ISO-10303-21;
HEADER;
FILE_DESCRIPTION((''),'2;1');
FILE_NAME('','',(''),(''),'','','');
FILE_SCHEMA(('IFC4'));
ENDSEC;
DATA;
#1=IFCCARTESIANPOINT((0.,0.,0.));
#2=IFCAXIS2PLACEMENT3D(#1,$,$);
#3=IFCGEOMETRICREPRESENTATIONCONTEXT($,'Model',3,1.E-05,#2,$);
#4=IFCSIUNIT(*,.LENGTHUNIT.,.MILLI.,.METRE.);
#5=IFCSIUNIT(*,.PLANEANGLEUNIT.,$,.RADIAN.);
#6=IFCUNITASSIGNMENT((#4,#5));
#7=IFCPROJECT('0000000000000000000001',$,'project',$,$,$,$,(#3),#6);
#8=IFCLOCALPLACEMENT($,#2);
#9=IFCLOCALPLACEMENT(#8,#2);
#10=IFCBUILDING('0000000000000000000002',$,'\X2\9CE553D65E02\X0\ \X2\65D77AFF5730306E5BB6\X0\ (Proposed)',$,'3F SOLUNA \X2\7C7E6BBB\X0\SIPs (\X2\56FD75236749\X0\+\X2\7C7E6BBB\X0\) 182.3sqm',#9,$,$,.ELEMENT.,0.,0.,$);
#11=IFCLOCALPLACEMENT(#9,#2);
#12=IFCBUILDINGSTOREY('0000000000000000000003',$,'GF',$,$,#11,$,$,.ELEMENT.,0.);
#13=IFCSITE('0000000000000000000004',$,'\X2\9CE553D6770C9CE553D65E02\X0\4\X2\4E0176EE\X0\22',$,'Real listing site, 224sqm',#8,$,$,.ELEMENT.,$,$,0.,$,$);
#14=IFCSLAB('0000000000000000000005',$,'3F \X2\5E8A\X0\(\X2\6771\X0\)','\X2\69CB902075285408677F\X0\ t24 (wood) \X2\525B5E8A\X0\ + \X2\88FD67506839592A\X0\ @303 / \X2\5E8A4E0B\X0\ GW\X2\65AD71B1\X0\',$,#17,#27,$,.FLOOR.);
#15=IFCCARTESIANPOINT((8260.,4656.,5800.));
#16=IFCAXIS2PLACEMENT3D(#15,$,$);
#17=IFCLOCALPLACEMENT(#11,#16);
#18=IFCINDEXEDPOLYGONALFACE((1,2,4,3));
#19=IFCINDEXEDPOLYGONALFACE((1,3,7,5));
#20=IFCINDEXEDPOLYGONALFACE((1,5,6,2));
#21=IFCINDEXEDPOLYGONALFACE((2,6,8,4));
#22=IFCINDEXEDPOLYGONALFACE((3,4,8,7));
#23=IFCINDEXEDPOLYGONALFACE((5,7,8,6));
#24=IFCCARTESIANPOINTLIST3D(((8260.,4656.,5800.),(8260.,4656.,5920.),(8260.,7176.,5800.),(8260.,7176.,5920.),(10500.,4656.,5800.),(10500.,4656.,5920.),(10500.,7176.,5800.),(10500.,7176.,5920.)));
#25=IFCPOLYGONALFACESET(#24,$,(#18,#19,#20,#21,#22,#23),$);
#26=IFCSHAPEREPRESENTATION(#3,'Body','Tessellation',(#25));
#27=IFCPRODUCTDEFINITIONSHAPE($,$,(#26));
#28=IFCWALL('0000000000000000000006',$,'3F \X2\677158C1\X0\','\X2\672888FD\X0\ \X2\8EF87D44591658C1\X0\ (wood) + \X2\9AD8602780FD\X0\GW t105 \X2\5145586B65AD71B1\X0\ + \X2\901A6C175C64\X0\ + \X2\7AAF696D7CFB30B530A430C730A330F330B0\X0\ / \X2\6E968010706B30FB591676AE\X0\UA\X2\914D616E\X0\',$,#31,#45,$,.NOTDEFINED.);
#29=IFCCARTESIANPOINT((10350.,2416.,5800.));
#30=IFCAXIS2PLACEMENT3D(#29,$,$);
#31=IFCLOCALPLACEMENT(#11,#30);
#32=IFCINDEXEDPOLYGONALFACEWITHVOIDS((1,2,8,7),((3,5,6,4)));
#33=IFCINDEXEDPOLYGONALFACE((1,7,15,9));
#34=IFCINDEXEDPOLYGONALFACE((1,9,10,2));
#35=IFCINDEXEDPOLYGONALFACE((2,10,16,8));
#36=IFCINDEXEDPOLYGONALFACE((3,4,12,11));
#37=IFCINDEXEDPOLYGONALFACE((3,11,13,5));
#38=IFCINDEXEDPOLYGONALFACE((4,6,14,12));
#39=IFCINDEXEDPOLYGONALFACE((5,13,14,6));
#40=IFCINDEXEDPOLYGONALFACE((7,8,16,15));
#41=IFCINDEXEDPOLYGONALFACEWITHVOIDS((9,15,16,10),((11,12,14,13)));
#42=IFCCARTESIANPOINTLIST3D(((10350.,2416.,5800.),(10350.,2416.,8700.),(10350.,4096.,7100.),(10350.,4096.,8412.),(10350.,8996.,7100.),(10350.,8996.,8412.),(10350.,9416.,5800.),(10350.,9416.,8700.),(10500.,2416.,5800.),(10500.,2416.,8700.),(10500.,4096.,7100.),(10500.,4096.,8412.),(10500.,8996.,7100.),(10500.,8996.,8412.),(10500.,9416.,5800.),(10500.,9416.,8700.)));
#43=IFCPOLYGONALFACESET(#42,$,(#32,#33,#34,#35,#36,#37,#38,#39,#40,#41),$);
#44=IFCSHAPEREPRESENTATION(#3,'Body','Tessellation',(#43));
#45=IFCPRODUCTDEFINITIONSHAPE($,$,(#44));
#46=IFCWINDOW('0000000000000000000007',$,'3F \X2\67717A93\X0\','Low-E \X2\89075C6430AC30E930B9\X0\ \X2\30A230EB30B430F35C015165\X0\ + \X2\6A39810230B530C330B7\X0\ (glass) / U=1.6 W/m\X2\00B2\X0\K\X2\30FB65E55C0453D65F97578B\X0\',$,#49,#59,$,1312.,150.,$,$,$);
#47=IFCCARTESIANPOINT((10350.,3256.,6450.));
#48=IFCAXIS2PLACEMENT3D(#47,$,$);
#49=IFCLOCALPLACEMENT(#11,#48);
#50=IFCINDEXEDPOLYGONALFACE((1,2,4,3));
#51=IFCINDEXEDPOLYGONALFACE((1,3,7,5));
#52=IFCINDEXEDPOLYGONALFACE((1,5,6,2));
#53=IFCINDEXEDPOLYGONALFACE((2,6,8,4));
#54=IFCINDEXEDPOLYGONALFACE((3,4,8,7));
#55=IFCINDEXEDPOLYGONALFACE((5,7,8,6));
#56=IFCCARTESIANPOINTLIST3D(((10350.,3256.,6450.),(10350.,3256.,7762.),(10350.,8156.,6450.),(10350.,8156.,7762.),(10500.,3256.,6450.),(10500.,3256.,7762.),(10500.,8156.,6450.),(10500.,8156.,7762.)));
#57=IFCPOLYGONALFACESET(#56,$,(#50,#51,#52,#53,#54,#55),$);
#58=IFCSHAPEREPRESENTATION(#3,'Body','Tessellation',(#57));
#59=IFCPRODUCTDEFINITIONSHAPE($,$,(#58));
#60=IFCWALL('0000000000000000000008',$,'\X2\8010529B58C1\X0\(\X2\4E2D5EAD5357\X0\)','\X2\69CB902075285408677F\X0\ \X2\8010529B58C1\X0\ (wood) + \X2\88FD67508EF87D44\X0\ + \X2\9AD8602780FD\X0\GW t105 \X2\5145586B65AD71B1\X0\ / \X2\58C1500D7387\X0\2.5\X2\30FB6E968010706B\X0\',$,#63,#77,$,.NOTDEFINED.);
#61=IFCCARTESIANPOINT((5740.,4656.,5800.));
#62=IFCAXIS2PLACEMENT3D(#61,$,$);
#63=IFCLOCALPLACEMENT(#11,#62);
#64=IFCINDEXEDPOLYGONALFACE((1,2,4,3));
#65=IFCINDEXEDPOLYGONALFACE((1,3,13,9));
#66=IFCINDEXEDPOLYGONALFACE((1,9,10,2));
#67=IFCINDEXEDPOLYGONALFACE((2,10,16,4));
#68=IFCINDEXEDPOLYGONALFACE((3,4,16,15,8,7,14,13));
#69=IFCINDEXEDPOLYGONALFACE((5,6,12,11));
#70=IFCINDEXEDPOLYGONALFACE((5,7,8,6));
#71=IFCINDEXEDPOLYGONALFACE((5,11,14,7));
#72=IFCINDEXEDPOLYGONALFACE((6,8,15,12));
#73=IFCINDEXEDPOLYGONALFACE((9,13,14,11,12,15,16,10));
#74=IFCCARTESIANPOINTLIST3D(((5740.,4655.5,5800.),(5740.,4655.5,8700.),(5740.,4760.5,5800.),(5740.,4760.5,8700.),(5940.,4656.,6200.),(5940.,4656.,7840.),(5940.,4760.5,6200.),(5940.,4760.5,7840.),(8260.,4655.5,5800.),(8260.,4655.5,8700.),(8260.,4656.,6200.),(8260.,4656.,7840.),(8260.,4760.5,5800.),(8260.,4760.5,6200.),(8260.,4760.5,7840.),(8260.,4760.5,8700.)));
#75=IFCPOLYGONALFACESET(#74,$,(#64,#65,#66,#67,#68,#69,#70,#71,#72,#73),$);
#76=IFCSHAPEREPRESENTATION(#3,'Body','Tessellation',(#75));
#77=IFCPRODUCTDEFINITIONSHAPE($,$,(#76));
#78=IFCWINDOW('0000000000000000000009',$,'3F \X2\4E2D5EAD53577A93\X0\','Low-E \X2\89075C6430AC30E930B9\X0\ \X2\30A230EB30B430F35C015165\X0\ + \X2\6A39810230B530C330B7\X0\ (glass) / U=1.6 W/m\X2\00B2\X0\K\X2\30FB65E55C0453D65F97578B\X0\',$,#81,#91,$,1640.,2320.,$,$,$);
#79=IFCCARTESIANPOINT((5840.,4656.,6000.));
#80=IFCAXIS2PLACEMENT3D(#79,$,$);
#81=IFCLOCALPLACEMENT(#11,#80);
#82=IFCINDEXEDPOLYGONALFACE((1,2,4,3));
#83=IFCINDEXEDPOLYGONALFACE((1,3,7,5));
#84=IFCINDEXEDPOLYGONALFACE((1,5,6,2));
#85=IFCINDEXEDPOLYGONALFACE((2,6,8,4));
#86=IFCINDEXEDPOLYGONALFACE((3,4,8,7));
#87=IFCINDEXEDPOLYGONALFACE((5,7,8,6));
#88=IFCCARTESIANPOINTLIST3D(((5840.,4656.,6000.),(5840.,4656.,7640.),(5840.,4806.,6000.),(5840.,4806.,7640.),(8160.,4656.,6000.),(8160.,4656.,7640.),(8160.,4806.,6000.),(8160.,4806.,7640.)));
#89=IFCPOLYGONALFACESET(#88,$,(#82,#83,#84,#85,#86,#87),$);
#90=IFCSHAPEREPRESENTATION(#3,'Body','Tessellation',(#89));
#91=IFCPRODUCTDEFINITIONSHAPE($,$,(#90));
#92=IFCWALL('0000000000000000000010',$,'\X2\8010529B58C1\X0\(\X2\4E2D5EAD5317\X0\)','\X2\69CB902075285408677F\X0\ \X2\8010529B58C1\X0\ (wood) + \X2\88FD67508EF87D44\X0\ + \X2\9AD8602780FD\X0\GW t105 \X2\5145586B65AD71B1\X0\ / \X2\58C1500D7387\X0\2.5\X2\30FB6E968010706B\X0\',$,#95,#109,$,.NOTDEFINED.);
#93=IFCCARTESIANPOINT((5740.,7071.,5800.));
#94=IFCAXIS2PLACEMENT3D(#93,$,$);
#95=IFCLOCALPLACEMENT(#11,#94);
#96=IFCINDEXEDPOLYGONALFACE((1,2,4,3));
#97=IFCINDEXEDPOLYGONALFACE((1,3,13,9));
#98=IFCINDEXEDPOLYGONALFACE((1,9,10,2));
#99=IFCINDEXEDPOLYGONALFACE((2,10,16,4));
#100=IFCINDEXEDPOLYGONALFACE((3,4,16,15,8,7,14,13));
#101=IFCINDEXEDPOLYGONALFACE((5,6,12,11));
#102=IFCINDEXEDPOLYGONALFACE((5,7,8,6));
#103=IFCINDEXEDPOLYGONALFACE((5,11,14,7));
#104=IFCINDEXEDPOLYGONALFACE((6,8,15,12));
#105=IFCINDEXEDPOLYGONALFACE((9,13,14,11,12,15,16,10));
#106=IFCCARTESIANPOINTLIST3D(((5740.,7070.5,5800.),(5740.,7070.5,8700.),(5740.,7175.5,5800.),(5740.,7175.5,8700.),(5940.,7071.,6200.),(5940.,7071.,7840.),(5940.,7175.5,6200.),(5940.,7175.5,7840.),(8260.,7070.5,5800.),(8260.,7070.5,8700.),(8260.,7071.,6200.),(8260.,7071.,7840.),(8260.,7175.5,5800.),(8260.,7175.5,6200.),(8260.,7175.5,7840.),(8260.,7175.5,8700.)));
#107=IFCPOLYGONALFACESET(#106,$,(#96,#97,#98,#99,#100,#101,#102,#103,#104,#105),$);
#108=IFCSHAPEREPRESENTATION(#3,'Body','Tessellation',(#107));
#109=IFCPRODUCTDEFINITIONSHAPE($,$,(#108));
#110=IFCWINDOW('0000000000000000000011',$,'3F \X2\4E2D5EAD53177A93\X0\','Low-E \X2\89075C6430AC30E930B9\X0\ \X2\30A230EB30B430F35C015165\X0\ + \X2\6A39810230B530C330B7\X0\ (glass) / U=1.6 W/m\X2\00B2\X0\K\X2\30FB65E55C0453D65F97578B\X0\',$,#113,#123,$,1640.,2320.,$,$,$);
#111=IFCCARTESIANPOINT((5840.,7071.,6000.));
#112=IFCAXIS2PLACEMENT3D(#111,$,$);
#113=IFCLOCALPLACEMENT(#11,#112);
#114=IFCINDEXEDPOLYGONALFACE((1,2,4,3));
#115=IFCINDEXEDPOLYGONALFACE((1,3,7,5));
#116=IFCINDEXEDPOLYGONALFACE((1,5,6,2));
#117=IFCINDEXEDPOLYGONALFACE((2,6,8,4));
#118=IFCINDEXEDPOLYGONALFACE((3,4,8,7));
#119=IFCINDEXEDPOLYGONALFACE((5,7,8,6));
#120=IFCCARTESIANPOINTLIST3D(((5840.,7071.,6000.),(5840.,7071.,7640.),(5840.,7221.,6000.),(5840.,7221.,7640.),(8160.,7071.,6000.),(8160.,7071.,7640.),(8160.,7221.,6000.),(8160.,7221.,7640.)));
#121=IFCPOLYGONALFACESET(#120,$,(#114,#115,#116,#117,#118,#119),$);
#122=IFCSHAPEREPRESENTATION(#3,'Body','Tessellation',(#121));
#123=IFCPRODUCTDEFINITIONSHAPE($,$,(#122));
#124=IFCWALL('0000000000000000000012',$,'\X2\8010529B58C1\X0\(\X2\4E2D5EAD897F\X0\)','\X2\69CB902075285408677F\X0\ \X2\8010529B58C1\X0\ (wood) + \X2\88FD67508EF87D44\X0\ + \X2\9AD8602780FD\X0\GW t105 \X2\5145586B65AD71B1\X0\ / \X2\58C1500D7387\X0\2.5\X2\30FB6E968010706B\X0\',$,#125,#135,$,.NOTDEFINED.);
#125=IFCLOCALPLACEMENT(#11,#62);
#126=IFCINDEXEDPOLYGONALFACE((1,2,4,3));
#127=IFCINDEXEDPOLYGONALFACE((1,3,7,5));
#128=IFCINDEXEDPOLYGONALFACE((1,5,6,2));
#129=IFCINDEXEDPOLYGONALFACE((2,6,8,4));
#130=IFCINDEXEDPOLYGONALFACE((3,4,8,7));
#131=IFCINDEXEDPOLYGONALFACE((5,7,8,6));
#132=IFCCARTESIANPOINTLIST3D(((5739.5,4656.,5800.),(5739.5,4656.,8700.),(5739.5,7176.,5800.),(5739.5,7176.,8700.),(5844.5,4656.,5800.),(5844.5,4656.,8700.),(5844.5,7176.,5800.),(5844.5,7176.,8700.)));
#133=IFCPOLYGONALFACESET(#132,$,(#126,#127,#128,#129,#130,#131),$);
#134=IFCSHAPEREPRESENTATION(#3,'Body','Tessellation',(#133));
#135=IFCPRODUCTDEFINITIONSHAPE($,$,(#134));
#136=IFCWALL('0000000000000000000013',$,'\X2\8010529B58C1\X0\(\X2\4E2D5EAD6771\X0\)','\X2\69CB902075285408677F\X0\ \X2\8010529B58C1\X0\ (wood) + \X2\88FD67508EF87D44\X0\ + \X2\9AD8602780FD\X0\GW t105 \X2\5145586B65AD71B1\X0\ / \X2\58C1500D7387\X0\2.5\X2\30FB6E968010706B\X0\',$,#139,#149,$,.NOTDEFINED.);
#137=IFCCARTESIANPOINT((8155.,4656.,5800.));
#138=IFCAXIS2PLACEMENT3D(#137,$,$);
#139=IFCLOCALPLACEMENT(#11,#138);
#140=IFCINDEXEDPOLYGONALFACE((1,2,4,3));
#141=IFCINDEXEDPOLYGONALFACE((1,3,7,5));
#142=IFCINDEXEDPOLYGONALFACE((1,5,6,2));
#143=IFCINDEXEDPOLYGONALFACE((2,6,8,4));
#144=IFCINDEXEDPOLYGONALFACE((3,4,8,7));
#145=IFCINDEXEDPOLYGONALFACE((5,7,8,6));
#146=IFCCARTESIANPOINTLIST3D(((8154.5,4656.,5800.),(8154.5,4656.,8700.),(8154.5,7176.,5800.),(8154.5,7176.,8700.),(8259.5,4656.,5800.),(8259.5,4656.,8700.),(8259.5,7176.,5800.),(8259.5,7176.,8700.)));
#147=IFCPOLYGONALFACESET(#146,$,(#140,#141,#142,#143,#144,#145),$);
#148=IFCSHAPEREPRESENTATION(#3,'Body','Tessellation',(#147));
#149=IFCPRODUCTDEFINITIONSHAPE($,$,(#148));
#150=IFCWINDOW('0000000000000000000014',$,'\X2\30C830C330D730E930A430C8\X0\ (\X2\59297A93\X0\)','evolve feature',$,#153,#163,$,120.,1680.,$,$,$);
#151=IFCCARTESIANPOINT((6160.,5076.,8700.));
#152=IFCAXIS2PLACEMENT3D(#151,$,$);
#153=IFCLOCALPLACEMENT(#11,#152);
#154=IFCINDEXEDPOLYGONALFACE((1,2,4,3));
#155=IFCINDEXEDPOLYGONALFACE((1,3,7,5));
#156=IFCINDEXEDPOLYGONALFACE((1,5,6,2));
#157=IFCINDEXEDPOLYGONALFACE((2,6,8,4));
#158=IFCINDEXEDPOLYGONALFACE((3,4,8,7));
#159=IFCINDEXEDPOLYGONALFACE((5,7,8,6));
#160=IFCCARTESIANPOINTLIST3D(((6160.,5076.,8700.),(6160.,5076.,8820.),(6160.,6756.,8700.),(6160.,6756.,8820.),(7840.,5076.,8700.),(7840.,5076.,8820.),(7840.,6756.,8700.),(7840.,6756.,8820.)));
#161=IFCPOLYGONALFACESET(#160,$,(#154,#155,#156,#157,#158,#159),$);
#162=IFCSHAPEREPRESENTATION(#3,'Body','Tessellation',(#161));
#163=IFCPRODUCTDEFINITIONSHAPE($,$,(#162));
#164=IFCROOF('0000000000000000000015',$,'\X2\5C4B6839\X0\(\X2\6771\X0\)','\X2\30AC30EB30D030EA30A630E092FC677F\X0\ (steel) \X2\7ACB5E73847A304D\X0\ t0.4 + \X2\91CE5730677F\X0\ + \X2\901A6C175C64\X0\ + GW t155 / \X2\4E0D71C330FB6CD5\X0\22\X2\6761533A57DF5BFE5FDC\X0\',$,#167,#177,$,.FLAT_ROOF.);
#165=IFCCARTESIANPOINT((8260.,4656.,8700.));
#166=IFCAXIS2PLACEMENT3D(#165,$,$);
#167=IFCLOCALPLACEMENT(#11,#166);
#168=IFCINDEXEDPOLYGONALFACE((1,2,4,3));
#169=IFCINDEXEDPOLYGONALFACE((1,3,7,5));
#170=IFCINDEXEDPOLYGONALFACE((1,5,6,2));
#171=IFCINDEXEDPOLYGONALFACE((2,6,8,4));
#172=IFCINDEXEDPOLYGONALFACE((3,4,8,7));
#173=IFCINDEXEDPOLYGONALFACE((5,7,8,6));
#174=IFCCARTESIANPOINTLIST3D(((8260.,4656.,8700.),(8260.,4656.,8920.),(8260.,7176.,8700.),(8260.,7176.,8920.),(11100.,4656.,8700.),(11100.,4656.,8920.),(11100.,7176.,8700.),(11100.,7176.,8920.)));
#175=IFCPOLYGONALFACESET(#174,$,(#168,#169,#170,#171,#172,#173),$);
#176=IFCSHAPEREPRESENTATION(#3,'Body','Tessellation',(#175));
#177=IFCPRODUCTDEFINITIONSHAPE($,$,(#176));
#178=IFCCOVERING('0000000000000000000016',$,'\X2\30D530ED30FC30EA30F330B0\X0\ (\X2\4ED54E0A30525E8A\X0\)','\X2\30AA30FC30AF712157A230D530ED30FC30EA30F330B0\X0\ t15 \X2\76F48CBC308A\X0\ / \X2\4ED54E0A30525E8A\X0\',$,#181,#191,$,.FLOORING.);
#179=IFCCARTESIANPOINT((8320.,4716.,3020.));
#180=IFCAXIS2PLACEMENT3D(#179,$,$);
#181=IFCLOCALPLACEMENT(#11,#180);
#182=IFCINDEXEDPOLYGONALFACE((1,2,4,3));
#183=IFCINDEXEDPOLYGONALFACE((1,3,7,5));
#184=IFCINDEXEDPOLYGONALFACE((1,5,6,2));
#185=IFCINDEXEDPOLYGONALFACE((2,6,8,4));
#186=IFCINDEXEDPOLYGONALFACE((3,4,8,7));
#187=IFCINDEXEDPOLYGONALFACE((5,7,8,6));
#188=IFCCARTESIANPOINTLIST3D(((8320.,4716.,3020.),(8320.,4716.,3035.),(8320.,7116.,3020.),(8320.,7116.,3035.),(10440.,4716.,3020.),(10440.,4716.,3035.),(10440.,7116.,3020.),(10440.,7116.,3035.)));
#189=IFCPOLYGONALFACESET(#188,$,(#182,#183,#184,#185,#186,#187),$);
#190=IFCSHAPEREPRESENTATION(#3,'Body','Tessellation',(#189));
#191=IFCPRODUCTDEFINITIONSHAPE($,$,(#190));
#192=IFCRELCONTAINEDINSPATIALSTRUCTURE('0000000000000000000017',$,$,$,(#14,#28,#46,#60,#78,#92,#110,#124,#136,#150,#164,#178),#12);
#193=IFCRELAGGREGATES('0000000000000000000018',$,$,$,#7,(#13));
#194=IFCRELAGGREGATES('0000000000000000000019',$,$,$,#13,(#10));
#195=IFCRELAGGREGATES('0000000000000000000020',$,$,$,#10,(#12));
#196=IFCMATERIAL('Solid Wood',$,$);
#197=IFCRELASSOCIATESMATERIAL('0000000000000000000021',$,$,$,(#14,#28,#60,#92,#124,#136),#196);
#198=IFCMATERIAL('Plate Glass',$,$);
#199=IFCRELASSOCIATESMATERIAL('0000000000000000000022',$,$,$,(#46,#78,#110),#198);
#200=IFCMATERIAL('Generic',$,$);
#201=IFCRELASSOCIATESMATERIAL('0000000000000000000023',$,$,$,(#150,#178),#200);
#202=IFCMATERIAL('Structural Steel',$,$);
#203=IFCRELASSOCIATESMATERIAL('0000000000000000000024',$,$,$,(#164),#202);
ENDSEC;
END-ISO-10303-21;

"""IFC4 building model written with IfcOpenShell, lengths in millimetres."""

from ifc_helpers import new_model, si_unit, frame, frame_2d, origin, place, context, project, spatial, rectangle, extrude, material, element, fill, save


model = new_model("IFC4")

# Units and contexts
model_context = context("Model", 3, precision=1e-05, world=origin())
ifc_project = project(units=[si_unit("LENGTHUNIT", "METRE", prefix="MILLI"), si_unit("PLANEANGLEUNIT", "RADIAN")], contexts=[model_context])

# Site, building, storey
site_placement = place(None, origin())
site = spatial("IfcSite", under=ifc_project, at=site_placement, Name="鳥取県鳥取市4丁目22", ObjectType="Real listing site, 224sqm", CompositionType="ELEMENT", RefElevation=0.0)
building_placement = place(site_placement, origin())
building = spatial("IfcBuilding", under=site, at=building_placement, Name="鳥取市 旗竿地の家 (Proposed)", ObjectType="3F SOLUNA 籾殻SIPs (国産杉+籾殻) 182.3sqm", CompositionType="ELEMENT", ElevationOfRefHeight=0.0, ElevationOfTerrain=0.0)
storey_placement = place(building_placement, origin())
storey = spatial("IfcBuildingStorey", under=building, at=storey_placement, Name="GF", CompositionType="ELEMENT", Elevation=0.0)

# Slab
ifc_material_1 = material(Name="Solid Wood")
slab_placement = place(storey_placement, frame((8260.0, 4656.0, 5800.0)))
element("IfcSlab", 1, at=slab_placement, inside=storey, material=ifc_material_1, Name="3F 床(東)", Description="構造用合板 t24 (wood) 剛床 + 製材根太 @303 / 床下 GW断熱", PredefinedType="FLOOR", context=model_context, shape_type="SweptSolid", body=[
    extrude(rectangle(XDim=2240.0, YDim=2520.0, at=frame_2d((1120.0, 1260.0))), frame((8260.0, 4656.0, 5800.0)), (0.0, 0.0, 1.0), 120.0),
])

# Walls, openings, windows
wall_1_placement = place(storey_placement, frame((10350.0, 2416.0, 5800.0)))
wall_1 = element("IfcWall", 2, at=wall_1_placement, inside=storey, material=ifc_material_1, Name="3F 東壁", Description="木製 軸組外壁 (wood) + 高性能GW t105 充填断熱 + 通気層 + 窯業系サイディング / 準耐火・外皮UA配慮", PredefinedType="NOTDEFINED", context=model_context, shape_type="SweptSolid", body=[
    extrude(rectangle(XDim=150.0, YDim=7000.0, at=frame_2d((75.0, 3500.0))), frame((10350.0, 2416.0, 5800.0)), (0.0, 0.0, 1.0), 2900.0),
])
opening_1_placement = place(storey_placement, frame((10350.0, 3256.0, 6450.0)))
opening_1 = element("IfcOpeningElement", 3, at=opening_1_placement, cuts=wall_1, PredefinedType="NOTDEFINED", context=model_context, shape_type="SweptSolid", body=[
    extrude(rectangle(XDim=150.0, YDim=4900.0, at=frame_2d((75.0, 2450.0))), frame((10350.0, 3256.0, 6450.0)), (0.0, 0.0, 1.0), 1312.0),
])
ifc_material_2 = material(Name="Plate Glass")
window_1_placement = place(storey_placement, frame((10350.0, 3256.0, 6450.0)))
window_1 = element("IfcWindow", 4, at=window_1_placement, inside=storey, material=ifc_material_2, Name="3F 東窓", Description="Low-E 複層ガラス アルゴン封入 + 樹脂サッシ (glass) / U=1.6 W/m²K・日射取得型", OverallHeight=1312.0, OverallWidth=150.0, context=model_context, shape_type="SweptSolid", body=[
    extrude(rectangle(XDim=150.0, YDim=4900.0, at=frame_2d((75.0, 2450.0))), frame((10350.0, 3256.0, 6450.0)), (0.0, 0.0, 1.0), 1312.0),
])
fill(opening_1, window_1)
wall_2_placement = place(storey_placement, frame((5740.0, 4656.0, 5800.0)))
wall_2 = element("IfcWall", 5, at=wall_2_placement, inside=storey, material=ifc_material_1, Name="耐力壁(中庭南)", Description="構造用合板 耐力壁 (wood) + 製材軸組 + 高性能GW t105 充填断熱 / 壁倍率2.5・準耐火", PredefinedType="NOTDEFINED", context=model_context, shape_type="SweptSolid", body=[
    extrude(rectangle(XDim=2520.0, YDim=105.0, at=frame_2d((1260.0, 52.0))), frame((5740.0, 4656.0, 5800.0)), (0.0, 0.0, 1.0), 2900.0),
])
opening_2_placement = place(storey_placement, frame((5840.0, 4656.0, 6000.0)))
opening_2 = element("IfcOpeningElement", 6, at=opening_2_placement, cuts=wall_2, PredefinedType="NOTDEFINED", context=model_context, shape_type="SweptSolid", body=[
    extrude(rectangle(XDim=2320.0, YDim=150.0, at=frame_2d((1160.0, 75.0))), frame((5840.0, 4656.0, 6000.0)), (0.0, 0.0, 1.0), 1640.0),
])
window_2_placement = place(storey_placement, frame((5840.0, 4656.0, 6000.0)))
window_2 = element("IfcWindow", 7, at=window_2_placement, inside=storey, material=ifc_material_2, Name="3F 中庭南窓", Description="Low-E 複層ガラス アルゴン封入 + 樹脂サッシ (glass) / U=1.6 W/m²K・日射取得型", OverallHeight=1640.0, OverallWidth=2320.0, context=model_context, shape_type="SweptSolid", body=[
    extrude(rectangle(XDim=2320.0, YDim=150.0, at=frame_2d((1160.0, 75.0))), frame((5840.0, 4656.0, 6000.0)), (0.0, 0.0, 1.0), 1640.0),
])
fill(opening_2, window_2)
wall_3_placement = place(storey_placement, frame((5740.0, 7071.0, 5800.0)))
wall_3 = element("IfcWall", 8, at=wall_3_placement, inside=storey, material=ifc_material_1, Name="耐力壁(中庭北)", Description="構造用合板 耐力壁 (wood) + 製材軸組 + 高性能GW t105 充填断熱 / 壁倍率2.5・準耐火", PredefinedType="NOTDEFINED", context=model_context, shape_type="SweptSolid", body=[
    extrude(rectangle(XDim=2520.0, YDim=105.0, at=frame_2d((1260.0, 52.0))), frame((5740.0, 7071.0, 5800.0)), (0.0, 0.0, 1.0), 2900.0),
])
opening_3_placement = place(storey_placement, frame((5840.0, 7071.0, 6000.0)))
opening_3 = element("IfcOpeningElement", 9, at=opening_3_placement, cuts=wall_3, PredefinedType="NOTDEFINED", context=model_context, shape_type="SweptSolid", body=[
    extrude(rectangle(XDim=2320.0, YDim=150.0, at=frame_2d((1160.0, 75.0))), frame((5840.0, 7071.0, 6000.0)), (0.0, 0.0, 1.0), 1640.0),
])
window_3_placement = place(storey_placement, frame((5840.0, 7071.0, 6000.0)))
window_3 = element("IfcWindow", 10, at=window_3_placement, inside=storey, material=ifc_material_2, Name="3F 中庭北窓", Description="Low-E 複層ガラス アルゴン封入 + 樹脂サッシ (glass) / U=1.6 W/m²K・日射取得型", OverallHeight=1640.0, OverallWidth=2320.0, context=model_context, shape_type="SweptSolid", body=[
    extrude(rectangle(XDim=2320.0, YDim=150.0, at=frame_2d((1160.0, 75.0))), frame((5840.0, 7071.0, 6000.0)), (0.0, 0.0, 1.0), 1640.0),
])
fill(opening_3, window_3)

# Walls
wall_4_placement = place(storey_placement, frame((5740.0, 4656.0, 5800.0)))
element("IfcWall", 11, at=wall_4_placement, inside=storey, material=ifc_material_1, Name="耐力壁(中庭西)", Description="構造用合板 耐力壁 (wood) + 製材軸組 + 高性能GW t105 充填断熱 / 壁倍率2.5・準耐火", PredefinedType="NOTDEFINED", context=model_context, shape_type="SweptSolid", body=[
    extrude(rectangle(XDim=105.0, YDim=2520.0, at=frame_2d((52.0, 1260.0))), frame((5740.0, 4656.0, 5800.0)), (0.0, 0.0, 1.0), 2900.0),
])
wall_5_placement = place(storey_placement, frame((8155.0, 4656.0, 5800.0)))
element("IfcWall", 12, at=wall_5_placement, inside=storey, material=ifc_material_1, Name="耐力壁(中庭東)", Description="構造用合板 耐力壁 (wood) + 製材軸組 + 高性能GW t105 充填断熱 / 壁倍率2.5・準耐火", PredefinedType="NOTDEFINED", context=model_context, shape_type="SweptSolid", body=[
    extrude(rectangle(XDim=105.0, YDim=2520.0, at=frame_2d((52.0, 1260.0))), frame((8155.0, 4656.0, 5800.0)), (0.0, 0.0, 1.0), 2900.0),
])

# Window
ifc_material_3 = material(Name="Generic")
window_4_placement = place(storey_placement, frame((6160.0, 5076.0, 8700.0)))
element("IfcWindow", 13, at=window_4_placement, inside=storey, material=ifc_material_3, Name="トップライト (天窓)", Description="evolve feature", OverallHeight=120.0, OverallWidth=1680.0, context=model_context, shape_type="SweptSolid", body=[
    extrude(rectangle(XDim=1680.0, YDim=1680.0, at=frame_2d((840.0, 840.0))), frame((6160.0, 5076.0, 8700.0)), (0.0, 0.0, 1.0), 120.0),
])

# Roof
ifc_material_4 = material(Name="Structural Steel")
for number, where, name in (
    (14, (8260.0, 4656.0, 8700.0), "屋根(東)"),
):
    element("IfcRoof", number, at=place(storey_placement, frame(where)), inside=storey, material=ifc_material_4, Name=name, Description="ガルバリウム鋼板 (steel) 立平葺き t0.4 + 野地板 + 通気層 + GW t155 / 不燃・法22条区域対応", PredefinedType="FLAT_ROOF", context=model_context, shape_type="SweptSolid", body=[
        extrude(rectangle(XDim=2840.0, YDim=2520.0, at=frame_2d((1420.0, 1260.0))), frame((8260.0, 4656.0, 8700.0)), (0.0, 0.0, 1.0), 220.0),
    ])

# Covering
covering_1_placement = place(storey_placement, frame((8320.0, 4716.0, 3020.0)))
element("IfcCovering", 15, at=covering_1_placement, inside=storey, material=ifc_material_3, Name="フローリング (仕上げ床)", Description="オーク無垢フローリング t15 直貼り / 仕上げ床", PredefinedType="FLOORING", context=model_context, shape_type="SweptSolid", body=[
    extrude(rectangle(XDim=2120.0, YDim=2400.0, at=frame_2d((1060.0, 1200.0))), frame((8320.0, 4716.0, 3020.0)), (0.0, 0.0, 1.0), 15.0),
])

save(model, "model.ifc")
